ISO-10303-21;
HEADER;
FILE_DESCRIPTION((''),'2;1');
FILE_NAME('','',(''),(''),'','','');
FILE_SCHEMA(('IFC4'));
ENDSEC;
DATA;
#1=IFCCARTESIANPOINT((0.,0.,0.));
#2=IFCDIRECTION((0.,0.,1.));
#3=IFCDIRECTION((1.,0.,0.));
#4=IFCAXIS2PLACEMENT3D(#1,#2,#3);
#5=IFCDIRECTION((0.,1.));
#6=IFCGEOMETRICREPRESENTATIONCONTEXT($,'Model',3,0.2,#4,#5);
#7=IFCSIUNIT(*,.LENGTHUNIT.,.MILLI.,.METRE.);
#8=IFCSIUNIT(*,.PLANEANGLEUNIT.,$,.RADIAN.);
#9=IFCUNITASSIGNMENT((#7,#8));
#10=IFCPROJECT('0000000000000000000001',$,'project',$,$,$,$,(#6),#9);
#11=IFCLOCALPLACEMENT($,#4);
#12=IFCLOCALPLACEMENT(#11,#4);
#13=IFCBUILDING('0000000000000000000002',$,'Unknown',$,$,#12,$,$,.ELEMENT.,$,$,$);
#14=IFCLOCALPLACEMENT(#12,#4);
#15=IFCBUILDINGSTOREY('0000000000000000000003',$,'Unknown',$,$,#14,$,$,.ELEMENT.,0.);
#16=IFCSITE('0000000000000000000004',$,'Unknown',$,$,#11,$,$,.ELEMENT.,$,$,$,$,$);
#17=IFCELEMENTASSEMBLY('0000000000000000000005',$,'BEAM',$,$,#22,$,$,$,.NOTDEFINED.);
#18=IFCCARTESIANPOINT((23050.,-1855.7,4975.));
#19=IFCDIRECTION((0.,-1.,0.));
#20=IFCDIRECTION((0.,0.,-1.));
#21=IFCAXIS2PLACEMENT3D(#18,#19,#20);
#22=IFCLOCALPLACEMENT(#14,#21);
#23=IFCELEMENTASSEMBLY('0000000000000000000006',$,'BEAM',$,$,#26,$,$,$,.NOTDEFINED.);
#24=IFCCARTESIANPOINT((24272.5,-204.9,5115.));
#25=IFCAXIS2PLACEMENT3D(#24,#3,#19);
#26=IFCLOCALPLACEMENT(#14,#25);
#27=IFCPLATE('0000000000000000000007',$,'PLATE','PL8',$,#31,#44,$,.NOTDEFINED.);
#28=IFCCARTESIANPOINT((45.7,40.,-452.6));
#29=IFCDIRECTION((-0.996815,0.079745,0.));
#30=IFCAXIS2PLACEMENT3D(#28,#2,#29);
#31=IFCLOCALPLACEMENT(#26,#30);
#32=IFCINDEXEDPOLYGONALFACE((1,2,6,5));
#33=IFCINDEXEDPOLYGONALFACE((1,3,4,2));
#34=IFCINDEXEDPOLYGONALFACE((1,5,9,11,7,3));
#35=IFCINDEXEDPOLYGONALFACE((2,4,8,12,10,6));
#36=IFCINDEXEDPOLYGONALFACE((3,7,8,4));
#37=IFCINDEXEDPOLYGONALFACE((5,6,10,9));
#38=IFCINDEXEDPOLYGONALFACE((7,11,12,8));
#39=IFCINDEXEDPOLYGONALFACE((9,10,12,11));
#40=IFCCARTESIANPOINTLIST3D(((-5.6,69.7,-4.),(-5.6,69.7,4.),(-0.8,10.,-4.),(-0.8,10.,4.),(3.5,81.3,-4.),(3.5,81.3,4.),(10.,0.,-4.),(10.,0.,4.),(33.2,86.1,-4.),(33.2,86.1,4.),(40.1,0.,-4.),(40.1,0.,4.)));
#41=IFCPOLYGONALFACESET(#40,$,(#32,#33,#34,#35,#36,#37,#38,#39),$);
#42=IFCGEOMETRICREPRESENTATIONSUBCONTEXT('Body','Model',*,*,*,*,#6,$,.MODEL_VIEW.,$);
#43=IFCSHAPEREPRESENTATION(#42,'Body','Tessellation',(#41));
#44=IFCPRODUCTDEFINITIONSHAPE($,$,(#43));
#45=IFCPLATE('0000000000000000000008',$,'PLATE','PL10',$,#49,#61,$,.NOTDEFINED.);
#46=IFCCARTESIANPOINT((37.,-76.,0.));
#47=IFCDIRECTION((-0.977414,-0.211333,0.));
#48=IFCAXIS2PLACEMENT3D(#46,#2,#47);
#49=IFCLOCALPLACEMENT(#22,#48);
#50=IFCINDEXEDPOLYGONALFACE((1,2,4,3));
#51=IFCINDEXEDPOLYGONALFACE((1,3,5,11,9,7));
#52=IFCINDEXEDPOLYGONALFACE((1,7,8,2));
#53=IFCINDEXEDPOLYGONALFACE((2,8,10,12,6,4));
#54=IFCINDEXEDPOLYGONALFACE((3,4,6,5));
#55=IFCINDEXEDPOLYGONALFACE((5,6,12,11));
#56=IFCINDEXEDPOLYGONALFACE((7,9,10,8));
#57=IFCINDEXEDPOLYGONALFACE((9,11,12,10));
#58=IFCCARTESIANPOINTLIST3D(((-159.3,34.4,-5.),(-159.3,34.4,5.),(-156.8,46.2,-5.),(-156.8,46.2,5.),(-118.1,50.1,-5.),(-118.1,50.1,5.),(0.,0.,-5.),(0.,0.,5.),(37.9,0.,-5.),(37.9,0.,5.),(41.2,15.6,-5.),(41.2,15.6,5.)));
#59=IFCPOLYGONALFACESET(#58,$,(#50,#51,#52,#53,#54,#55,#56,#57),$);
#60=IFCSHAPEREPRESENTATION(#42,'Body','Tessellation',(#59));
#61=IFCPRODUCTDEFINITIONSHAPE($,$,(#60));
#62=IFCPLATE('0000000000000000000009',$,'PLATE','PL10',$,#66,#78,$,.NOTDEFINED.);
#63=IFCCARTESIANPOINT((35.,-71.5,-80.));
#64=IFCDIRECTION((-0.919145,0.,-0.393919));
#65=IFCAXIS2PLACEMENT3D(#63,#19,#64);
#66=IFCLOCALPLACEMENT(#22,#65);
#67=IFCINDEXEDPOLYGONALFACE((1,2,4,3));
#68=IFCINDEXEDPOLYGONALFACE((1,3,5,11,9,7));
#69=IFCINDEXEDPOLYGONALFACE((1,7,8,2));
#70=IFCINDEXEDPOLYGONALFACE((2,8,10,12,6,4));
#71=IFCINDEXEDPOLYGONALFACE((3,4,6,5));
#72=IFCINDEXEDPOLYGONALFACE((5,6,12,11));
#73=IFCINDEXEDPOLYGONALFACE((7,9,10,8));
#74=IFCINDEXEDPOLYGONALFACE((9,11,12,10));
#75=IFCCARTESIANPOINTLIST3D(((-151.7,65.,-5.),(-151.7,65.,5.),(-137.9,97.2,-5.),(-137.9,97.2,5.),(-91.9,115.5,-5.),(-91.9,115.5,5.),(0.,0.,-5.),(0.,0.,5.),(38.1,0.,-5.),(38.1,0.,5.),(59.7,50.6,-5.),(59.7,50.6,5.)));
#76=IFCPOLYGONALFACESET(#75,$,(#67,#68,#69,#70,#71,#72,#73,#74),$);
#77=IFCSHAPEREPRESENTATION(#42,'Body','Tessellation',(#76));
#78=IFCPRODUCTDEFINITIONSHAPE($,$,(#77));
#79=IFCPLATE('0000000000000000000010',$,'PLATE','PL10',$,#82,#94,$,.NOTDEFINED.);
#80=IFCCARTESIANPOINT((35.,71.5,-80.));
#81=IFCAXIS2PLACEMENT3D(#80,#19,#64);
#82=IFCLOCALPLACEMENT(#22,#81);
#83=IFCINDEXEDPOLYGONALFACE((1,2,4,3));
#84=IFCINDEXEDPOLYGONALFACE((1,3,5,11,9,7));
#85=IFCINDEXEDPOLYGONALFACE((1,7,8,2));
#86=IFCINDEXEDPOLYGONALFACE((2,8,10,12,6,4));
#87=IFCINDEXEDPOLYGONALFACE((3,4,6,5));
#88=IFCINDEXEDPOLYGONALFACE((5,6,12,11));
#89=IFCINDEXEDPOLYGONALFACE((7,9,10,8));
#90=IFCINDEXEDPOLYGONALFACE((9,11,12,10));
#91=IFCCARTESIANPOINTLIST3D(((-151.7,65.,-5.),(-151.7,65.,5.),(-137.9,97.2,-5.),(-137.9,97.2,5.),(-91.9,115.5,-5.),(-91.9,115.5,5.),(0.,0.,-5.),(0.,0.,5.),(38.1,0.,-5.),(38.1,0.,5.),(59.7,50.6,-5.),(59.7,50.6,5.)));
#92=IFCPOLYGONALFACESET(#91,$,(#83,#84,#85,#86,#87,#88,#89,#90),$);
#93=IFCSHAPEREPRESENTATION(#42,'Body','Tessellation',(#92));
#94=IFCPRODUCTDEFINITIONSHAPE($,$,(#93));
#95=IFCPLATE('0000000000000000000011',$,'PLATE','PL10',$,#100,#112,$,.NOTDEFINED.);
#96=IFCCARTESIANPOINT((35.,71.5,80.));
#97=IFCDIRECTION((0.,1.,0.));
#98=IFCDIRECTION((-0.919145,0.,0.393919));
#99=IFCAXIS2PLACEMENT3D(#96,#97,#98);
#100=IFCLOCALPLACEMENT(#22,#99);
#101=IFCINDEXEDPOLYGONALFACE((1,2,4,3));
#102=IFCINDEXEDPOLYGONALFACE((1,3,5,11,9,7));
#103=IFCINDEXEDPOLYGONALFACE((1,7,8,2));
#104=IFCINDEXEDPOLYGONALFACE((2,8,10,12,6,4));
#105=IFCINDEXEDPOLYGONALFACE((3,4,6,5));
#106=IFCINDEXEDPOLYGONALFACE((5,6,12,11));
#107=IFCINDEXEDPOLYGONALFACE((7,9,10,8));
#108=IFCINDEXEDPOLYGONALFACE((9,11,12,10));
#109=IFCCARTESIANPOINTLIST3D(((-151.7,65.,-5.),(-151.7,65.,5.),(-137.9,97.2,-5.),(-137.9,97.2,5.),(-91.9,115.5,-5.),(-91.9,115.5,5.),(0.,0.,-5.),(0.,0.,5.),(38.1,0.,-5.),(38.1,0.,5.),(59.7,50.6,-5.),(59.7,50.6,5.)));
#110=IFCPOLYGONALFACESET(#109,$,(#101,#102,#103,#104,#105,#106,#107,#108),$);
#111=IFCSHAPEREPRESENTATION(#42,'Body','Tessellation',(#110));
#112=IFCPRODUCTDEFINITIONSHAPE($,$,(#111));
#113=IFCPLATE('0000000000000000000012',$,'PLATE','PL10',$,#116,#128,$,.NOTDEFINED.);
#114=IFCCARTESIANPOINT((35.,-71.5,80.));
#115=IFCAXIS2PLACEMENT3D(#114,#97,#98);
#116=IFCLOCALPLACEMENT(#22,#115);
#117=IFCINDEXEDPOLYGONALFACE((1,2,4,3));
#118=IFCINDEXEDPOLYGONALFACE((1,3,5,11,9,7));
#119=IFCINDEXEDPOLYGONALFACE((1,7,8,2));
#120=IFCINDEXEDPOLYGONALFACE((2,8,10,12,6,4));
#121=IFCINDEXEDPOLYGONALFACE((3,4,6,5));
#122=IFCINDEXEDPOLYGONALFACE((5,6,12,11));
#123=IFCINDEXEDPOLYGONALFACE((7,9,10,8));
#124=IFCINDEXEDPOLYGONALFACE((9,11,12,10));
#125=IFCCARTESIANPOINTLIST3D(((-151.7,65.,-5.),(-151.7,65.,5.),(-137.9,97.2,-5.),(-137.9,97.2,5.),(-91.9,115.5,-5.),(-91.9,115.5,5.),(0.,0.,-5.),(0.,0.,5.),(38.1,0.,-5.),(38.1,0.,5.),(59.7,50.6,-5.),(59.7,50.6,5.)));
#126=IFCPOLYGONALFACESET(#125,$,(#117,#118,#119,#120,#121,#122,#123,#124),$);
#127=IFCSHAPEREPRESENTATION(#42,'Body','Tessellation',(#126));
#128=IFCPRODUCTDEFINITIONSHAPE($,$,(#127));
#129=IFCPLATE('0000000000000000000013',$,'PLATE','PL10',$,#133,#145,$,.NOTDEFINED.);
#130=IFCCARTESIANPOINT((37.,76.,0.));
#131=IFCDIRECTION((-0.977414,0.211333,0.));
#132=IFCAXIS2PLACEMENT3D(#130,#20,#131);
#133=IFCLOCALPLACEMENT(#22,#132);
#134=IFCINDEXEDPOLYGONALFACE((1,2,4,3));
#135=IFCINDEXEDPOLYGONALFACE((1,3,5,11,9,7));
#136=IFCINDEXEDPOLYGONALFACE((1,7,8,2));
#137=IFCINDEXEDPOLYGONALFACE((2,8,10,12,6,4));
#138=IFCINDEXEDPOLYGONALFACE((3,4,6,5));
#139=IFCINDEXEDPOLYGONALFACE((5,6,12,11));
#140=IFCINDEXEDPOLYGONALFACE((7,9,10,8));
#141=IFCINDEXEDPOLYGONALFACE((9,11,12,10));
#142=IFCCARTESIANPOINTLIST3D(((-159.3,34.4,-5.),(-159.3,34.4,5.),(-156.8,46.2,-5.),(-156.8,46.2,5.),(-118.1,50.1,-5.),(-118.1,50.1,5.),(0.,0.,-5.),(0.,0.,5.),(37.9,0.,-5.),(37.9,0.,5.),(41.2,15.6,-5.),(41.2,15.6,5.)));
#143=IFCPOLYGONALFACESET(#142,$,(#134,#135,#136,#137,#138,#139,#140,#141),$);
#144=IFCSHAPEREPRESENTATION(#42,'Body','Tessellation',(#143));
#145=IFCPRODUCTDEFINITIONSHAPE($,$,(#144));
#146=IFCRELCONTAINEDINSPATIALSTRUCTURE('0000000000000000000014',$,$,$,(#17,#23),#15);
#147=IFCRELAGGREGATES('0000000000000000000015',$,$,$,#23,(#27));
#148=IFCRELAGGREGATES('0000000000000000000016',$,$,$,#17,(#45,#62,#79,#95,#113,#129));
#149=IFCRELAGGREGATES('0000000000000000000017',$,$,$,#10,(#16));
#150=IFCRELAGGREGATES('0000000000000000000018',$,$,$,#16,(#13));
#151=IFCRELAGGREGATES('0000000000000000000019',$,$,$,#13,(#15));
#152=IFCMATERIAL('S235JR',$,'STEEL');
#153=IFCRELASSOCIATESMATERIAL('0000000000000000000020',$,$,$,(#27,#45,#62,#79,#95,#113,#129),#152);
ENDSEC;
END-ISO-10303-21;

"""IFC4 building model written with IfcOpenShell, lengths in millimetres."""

from ifc_helpers import new_model, si_unit, direction, frame, origin_with_axes, place, context, subcontext, project, spatial, line, indexed_curve, outline, extrude, material, element, aggregate, save


model = new_model("IFC4")

# Units and contexts
model_context = context("Model", 3, precision=0.2, world=origin_with_axes(), true_north=direction((0.0, 1.0)))
body_context = subcontext(model_context, "Body", "Model", "MODEL_VIEW")
ifc_project = project(units=[si_unit("LENGTHUNIT", "METRE", prefix="MILLI"), si_unit("PLANEANGLEUNIT", "RADIAN")], contexts=[model_context])

# Site, building, storey
site_placement = place(None, origin_with_axes())
site = spatial("IfcSite", under=ifc_project, at=site_placement, Name="Unknown", CompositionType="ELEMENT")
building_placement = place(site_placement, origin_with_axes())
building = spatial("IfcBuilding", under=site, at=building_placement, Name="Unknown", CompositionType="ELEMENT")
storey_placement = place(building_placement, origin_with_axes())
storey = spatial("IfcBuildingStorey", under=building, at=storey_placement, Name="Unknown", CompositionType="ELEMENT", Elevation=0.0)

# Element assembly
ifc_material_1 = material(Name="S235JR", Category="STEEL")
assembly_1_placement = place(storey_placement, frame((23050.0, -1855.7, 4975.0), z_axis=(0.0, -1.0, 0.0), x_axis=(0.0, 0.0, -1.0)))
assembly_1 = element("IfcElementAssembly", 1, at=assembly_1_placement, inside=storey, Name="BEAM", PredefinedType="NOTDEFINED")

# Element assembly, plate
assembly_2_placement = place(storey_placement, frame((24272.5, -204.9, 5115.0), z_axis=(1.0, 0.0, 0.0), x_axis=(0.0, -1.0, 0.0)))
assembly_2 = element("IfcElementAssembly", 2, at=assembly_2_placement, inside=storey, Name="BEAM", PredefinedType="NOTDEFINED")
plate_1_placement = place(assembly_2_placement, frame((45.7, 40.0, -452.6), z_axis=(0.0, 0.0, 1.0), x_axis=(-0.996815, 0.079745, 0.0)))
plate_1 = element("IfcPlate", 3, at=plate_1_placement, material=ifc_material_1, Name="PLATE", Description="PL8", PredefinedType="NOTDEFINED", context=body_context, shape_type="SolidModel", body=[
    extrude(outline(indexed_curve([(-0.8, 10.0), (10.0, 0.0), (40.1, 0.0), (33.2, 86.1), (3.5, 81.3), (-5.6, 69.7)], segments=[line(1, 2, 3, 4, 5, 6, 1)])), frame((0.0, 0.0, 4.0), z_axis=(0.0, 0.0, 1.0), x_axis=(1.0, 0.0, 0.0)), (0.0, 0.0, -1.0), 8.0),
])
aggregate(assembly_2, [plate_1])

# Plates
plate_2_placement = place(assembly_1_placement, frame((37.0, -76.0, 0.0), z_axis=(0.0, 0.0, 1.0), x_axis=(-0.977414, -0.211333, 0.0)))
plate_2 = element("IfcPlate", 4, at=plate_2_placement, material=ifc_material_1, Name="PLATE", Description="PL10", PredefinedType="NOTDEFINED", context=body_context, shape_type="SolidModel", body=[
    extrude(outline(indexed_curve([(0.0, 0.0), (37.9, 0.0), (41.2, 15.6), (-118.1, 50.1), (-156.8, 46.2), (-159.3, 34.4)], segments=[line(1, 2, 3, 4, 5, 6, 1)])), frame((0.0, 0.0, 5.0), z_axis=(0.0, 0.0, 1.0), x_axis=(1.0, 0.0, 0.0)), (0.0, 0.0, -1.0), 10.0),
])
plate_3_placement = place(assembly_1_placement, frame((35.0, -71.5, -80.0), z_axis=(0.0, -1.0, 0.0), x_axis=(-0.919145, 0.0, -0.393919)))
plate_3 = element("IfcPlate", 5, at=plate_3_placement, material=ifc_material_1, Name="PLATE", Description="PL10", PredefinedType="NOTDEFINED", context=body_context, shape_type="SolidModel", body=[
    extrude(outline(indexed_curve([(0.0, 0.0), (38.1, 0.0), (59.7, 50.6), (-91.9, 115.5), (-137.9, 97.2), (-151.7, 65.0)], segments=[line(1, 2, 3, 4, 5, 6, 1)])), frame((0.0, 0.0, 5.0), z_axis=(0.0, 0.0, 1.0), x_axis=(1.0, 0.0, 0.0)), (0.0, 0.0, -1.0), 10.0),
])
plate_4_placement = place(assembly_1_placement, frame((35.0, 71.5, -80.0), z_axis=(0.0, -1.0, 0.0), x_axis=(-0.919145, 0.0, -0.393919)))
plate_4 = element("IfcPlate", 6, at=plate_4_placement, material=ifc_material_1, Name="PLATE", Description="PL10", PredefinedType="NOTDEFINED", context=body_context, shape_type="SolidModel", body=[
    extrude(outline(indexed_curve([(0.0, 0.0), (38.1, 0.0), (59.7, 50.6), (-91.9, 115.5), (-137.9, 97.2), (-151.7, 65.0)], segments=[line(1, 2, 3, 4, 5, 6, 1)])), frame((0.0, 0.0, 5.0), z_axis=(0.0, 0.0, 1.0), x_axis=(1.0, 0.0, 0.0)), (0.0, 0.0, -1.0), 10.0),
])
plate_5_placement = place(assembly_1_placement, frame((35.0, 71.5, 80.0), z_axis=(0.0, 1.0, 0.0), x_axis=(-0.919145, 0.0, 0.393919)))
plate_5 = element("IfcPlate", 7, at=plate_5_placement, material=ifc_material_1, Name="PLATE", Description="PL10", PredefinedType="NOTDEFINED", context=body_context, shape_type="SolidModel", body=[
    extrude(outline(indexed_curve([(0.0, 0.0), (38.1, 0.0), (59.7, 50.6), (-91.9, 115.5), (-137.9, 97.2), (-151.7, 65.0)], segments=[line(1, 2, 3, 4, 5, 6, 1)])), frame((0.0, 0.0, 5.0), z_axis=(0.0, 0.0, 1.0), x_axis=(1.0, 0.0, 0.0)), (0.0, 0.0, -1.0), 10.0),
])
plate_6_placement = place(assembly_1_placement, frame((35.0, -71.5, 80.0), z_axis=(0.0, 1.0, 0.0), x_axis=(-0.919145, 0.0, 0.393919)))
plate_6 = element("IfcPlate", 8, at=plate_6_placement, material=ifc_material_1, Name="PLATE", Description="PL10", PredefinedType="NOTDEFINED", context=body_context, shape_type="SolidModel", body=[
    extrude(outline(indexed_curve([(0.0, 0.0), (38.1, 0.0), (59.7, 50.6), (-91.9, 115.5), (-137.9, 97.2), (-151.7, 65.0)], segments=[line(1, 2, 3, 4, 5, 6, 1)])), frame((0.0, 0.0, 5.0), z_axis=(0.0, 0.0, 1.0), x_axis=(1.0, 0.0, 0.0)), (0.0, 0.0, -1.0), 10.0),
])
plate_7_placement = place(assembly_1_placement, frame((37.0, 76.0, 0.0), z_axis=(0.0, 0.0, -1.0), x_axis=(-0.977414, 0.211333, 0.0)))
plate_7 = element("IfcPlate", 9, at=plate_7_placement, material=ifc_material_1, Name="PLATE", Description="PL10", PredefinedType="NOTDEFINED", context=body_context, shape_type="SolidModel", body=[
    extrude(outline(indexed_curve([(0.0, 0.0), (37.9, 0.0), (41.2, 15.6), (-118.1, 50.1), (-156.8, 46.2), (-159.3, 34.4)], segments=[line(1, 2, 3, 4, 5, 6, 1)])), frame((0.0, 0.0, 5.0), z_axis=(0.0, 0.0, 1.0), x_axis=(1.0, 0.0, 0.0)), (0.0, 0.0, -1.0), 10.0),
])
aggregate(assembly_1, [plate_2, plate_3, plate_4, plate_5, plate_6, plate_7])

save(model, "model.ifc")
